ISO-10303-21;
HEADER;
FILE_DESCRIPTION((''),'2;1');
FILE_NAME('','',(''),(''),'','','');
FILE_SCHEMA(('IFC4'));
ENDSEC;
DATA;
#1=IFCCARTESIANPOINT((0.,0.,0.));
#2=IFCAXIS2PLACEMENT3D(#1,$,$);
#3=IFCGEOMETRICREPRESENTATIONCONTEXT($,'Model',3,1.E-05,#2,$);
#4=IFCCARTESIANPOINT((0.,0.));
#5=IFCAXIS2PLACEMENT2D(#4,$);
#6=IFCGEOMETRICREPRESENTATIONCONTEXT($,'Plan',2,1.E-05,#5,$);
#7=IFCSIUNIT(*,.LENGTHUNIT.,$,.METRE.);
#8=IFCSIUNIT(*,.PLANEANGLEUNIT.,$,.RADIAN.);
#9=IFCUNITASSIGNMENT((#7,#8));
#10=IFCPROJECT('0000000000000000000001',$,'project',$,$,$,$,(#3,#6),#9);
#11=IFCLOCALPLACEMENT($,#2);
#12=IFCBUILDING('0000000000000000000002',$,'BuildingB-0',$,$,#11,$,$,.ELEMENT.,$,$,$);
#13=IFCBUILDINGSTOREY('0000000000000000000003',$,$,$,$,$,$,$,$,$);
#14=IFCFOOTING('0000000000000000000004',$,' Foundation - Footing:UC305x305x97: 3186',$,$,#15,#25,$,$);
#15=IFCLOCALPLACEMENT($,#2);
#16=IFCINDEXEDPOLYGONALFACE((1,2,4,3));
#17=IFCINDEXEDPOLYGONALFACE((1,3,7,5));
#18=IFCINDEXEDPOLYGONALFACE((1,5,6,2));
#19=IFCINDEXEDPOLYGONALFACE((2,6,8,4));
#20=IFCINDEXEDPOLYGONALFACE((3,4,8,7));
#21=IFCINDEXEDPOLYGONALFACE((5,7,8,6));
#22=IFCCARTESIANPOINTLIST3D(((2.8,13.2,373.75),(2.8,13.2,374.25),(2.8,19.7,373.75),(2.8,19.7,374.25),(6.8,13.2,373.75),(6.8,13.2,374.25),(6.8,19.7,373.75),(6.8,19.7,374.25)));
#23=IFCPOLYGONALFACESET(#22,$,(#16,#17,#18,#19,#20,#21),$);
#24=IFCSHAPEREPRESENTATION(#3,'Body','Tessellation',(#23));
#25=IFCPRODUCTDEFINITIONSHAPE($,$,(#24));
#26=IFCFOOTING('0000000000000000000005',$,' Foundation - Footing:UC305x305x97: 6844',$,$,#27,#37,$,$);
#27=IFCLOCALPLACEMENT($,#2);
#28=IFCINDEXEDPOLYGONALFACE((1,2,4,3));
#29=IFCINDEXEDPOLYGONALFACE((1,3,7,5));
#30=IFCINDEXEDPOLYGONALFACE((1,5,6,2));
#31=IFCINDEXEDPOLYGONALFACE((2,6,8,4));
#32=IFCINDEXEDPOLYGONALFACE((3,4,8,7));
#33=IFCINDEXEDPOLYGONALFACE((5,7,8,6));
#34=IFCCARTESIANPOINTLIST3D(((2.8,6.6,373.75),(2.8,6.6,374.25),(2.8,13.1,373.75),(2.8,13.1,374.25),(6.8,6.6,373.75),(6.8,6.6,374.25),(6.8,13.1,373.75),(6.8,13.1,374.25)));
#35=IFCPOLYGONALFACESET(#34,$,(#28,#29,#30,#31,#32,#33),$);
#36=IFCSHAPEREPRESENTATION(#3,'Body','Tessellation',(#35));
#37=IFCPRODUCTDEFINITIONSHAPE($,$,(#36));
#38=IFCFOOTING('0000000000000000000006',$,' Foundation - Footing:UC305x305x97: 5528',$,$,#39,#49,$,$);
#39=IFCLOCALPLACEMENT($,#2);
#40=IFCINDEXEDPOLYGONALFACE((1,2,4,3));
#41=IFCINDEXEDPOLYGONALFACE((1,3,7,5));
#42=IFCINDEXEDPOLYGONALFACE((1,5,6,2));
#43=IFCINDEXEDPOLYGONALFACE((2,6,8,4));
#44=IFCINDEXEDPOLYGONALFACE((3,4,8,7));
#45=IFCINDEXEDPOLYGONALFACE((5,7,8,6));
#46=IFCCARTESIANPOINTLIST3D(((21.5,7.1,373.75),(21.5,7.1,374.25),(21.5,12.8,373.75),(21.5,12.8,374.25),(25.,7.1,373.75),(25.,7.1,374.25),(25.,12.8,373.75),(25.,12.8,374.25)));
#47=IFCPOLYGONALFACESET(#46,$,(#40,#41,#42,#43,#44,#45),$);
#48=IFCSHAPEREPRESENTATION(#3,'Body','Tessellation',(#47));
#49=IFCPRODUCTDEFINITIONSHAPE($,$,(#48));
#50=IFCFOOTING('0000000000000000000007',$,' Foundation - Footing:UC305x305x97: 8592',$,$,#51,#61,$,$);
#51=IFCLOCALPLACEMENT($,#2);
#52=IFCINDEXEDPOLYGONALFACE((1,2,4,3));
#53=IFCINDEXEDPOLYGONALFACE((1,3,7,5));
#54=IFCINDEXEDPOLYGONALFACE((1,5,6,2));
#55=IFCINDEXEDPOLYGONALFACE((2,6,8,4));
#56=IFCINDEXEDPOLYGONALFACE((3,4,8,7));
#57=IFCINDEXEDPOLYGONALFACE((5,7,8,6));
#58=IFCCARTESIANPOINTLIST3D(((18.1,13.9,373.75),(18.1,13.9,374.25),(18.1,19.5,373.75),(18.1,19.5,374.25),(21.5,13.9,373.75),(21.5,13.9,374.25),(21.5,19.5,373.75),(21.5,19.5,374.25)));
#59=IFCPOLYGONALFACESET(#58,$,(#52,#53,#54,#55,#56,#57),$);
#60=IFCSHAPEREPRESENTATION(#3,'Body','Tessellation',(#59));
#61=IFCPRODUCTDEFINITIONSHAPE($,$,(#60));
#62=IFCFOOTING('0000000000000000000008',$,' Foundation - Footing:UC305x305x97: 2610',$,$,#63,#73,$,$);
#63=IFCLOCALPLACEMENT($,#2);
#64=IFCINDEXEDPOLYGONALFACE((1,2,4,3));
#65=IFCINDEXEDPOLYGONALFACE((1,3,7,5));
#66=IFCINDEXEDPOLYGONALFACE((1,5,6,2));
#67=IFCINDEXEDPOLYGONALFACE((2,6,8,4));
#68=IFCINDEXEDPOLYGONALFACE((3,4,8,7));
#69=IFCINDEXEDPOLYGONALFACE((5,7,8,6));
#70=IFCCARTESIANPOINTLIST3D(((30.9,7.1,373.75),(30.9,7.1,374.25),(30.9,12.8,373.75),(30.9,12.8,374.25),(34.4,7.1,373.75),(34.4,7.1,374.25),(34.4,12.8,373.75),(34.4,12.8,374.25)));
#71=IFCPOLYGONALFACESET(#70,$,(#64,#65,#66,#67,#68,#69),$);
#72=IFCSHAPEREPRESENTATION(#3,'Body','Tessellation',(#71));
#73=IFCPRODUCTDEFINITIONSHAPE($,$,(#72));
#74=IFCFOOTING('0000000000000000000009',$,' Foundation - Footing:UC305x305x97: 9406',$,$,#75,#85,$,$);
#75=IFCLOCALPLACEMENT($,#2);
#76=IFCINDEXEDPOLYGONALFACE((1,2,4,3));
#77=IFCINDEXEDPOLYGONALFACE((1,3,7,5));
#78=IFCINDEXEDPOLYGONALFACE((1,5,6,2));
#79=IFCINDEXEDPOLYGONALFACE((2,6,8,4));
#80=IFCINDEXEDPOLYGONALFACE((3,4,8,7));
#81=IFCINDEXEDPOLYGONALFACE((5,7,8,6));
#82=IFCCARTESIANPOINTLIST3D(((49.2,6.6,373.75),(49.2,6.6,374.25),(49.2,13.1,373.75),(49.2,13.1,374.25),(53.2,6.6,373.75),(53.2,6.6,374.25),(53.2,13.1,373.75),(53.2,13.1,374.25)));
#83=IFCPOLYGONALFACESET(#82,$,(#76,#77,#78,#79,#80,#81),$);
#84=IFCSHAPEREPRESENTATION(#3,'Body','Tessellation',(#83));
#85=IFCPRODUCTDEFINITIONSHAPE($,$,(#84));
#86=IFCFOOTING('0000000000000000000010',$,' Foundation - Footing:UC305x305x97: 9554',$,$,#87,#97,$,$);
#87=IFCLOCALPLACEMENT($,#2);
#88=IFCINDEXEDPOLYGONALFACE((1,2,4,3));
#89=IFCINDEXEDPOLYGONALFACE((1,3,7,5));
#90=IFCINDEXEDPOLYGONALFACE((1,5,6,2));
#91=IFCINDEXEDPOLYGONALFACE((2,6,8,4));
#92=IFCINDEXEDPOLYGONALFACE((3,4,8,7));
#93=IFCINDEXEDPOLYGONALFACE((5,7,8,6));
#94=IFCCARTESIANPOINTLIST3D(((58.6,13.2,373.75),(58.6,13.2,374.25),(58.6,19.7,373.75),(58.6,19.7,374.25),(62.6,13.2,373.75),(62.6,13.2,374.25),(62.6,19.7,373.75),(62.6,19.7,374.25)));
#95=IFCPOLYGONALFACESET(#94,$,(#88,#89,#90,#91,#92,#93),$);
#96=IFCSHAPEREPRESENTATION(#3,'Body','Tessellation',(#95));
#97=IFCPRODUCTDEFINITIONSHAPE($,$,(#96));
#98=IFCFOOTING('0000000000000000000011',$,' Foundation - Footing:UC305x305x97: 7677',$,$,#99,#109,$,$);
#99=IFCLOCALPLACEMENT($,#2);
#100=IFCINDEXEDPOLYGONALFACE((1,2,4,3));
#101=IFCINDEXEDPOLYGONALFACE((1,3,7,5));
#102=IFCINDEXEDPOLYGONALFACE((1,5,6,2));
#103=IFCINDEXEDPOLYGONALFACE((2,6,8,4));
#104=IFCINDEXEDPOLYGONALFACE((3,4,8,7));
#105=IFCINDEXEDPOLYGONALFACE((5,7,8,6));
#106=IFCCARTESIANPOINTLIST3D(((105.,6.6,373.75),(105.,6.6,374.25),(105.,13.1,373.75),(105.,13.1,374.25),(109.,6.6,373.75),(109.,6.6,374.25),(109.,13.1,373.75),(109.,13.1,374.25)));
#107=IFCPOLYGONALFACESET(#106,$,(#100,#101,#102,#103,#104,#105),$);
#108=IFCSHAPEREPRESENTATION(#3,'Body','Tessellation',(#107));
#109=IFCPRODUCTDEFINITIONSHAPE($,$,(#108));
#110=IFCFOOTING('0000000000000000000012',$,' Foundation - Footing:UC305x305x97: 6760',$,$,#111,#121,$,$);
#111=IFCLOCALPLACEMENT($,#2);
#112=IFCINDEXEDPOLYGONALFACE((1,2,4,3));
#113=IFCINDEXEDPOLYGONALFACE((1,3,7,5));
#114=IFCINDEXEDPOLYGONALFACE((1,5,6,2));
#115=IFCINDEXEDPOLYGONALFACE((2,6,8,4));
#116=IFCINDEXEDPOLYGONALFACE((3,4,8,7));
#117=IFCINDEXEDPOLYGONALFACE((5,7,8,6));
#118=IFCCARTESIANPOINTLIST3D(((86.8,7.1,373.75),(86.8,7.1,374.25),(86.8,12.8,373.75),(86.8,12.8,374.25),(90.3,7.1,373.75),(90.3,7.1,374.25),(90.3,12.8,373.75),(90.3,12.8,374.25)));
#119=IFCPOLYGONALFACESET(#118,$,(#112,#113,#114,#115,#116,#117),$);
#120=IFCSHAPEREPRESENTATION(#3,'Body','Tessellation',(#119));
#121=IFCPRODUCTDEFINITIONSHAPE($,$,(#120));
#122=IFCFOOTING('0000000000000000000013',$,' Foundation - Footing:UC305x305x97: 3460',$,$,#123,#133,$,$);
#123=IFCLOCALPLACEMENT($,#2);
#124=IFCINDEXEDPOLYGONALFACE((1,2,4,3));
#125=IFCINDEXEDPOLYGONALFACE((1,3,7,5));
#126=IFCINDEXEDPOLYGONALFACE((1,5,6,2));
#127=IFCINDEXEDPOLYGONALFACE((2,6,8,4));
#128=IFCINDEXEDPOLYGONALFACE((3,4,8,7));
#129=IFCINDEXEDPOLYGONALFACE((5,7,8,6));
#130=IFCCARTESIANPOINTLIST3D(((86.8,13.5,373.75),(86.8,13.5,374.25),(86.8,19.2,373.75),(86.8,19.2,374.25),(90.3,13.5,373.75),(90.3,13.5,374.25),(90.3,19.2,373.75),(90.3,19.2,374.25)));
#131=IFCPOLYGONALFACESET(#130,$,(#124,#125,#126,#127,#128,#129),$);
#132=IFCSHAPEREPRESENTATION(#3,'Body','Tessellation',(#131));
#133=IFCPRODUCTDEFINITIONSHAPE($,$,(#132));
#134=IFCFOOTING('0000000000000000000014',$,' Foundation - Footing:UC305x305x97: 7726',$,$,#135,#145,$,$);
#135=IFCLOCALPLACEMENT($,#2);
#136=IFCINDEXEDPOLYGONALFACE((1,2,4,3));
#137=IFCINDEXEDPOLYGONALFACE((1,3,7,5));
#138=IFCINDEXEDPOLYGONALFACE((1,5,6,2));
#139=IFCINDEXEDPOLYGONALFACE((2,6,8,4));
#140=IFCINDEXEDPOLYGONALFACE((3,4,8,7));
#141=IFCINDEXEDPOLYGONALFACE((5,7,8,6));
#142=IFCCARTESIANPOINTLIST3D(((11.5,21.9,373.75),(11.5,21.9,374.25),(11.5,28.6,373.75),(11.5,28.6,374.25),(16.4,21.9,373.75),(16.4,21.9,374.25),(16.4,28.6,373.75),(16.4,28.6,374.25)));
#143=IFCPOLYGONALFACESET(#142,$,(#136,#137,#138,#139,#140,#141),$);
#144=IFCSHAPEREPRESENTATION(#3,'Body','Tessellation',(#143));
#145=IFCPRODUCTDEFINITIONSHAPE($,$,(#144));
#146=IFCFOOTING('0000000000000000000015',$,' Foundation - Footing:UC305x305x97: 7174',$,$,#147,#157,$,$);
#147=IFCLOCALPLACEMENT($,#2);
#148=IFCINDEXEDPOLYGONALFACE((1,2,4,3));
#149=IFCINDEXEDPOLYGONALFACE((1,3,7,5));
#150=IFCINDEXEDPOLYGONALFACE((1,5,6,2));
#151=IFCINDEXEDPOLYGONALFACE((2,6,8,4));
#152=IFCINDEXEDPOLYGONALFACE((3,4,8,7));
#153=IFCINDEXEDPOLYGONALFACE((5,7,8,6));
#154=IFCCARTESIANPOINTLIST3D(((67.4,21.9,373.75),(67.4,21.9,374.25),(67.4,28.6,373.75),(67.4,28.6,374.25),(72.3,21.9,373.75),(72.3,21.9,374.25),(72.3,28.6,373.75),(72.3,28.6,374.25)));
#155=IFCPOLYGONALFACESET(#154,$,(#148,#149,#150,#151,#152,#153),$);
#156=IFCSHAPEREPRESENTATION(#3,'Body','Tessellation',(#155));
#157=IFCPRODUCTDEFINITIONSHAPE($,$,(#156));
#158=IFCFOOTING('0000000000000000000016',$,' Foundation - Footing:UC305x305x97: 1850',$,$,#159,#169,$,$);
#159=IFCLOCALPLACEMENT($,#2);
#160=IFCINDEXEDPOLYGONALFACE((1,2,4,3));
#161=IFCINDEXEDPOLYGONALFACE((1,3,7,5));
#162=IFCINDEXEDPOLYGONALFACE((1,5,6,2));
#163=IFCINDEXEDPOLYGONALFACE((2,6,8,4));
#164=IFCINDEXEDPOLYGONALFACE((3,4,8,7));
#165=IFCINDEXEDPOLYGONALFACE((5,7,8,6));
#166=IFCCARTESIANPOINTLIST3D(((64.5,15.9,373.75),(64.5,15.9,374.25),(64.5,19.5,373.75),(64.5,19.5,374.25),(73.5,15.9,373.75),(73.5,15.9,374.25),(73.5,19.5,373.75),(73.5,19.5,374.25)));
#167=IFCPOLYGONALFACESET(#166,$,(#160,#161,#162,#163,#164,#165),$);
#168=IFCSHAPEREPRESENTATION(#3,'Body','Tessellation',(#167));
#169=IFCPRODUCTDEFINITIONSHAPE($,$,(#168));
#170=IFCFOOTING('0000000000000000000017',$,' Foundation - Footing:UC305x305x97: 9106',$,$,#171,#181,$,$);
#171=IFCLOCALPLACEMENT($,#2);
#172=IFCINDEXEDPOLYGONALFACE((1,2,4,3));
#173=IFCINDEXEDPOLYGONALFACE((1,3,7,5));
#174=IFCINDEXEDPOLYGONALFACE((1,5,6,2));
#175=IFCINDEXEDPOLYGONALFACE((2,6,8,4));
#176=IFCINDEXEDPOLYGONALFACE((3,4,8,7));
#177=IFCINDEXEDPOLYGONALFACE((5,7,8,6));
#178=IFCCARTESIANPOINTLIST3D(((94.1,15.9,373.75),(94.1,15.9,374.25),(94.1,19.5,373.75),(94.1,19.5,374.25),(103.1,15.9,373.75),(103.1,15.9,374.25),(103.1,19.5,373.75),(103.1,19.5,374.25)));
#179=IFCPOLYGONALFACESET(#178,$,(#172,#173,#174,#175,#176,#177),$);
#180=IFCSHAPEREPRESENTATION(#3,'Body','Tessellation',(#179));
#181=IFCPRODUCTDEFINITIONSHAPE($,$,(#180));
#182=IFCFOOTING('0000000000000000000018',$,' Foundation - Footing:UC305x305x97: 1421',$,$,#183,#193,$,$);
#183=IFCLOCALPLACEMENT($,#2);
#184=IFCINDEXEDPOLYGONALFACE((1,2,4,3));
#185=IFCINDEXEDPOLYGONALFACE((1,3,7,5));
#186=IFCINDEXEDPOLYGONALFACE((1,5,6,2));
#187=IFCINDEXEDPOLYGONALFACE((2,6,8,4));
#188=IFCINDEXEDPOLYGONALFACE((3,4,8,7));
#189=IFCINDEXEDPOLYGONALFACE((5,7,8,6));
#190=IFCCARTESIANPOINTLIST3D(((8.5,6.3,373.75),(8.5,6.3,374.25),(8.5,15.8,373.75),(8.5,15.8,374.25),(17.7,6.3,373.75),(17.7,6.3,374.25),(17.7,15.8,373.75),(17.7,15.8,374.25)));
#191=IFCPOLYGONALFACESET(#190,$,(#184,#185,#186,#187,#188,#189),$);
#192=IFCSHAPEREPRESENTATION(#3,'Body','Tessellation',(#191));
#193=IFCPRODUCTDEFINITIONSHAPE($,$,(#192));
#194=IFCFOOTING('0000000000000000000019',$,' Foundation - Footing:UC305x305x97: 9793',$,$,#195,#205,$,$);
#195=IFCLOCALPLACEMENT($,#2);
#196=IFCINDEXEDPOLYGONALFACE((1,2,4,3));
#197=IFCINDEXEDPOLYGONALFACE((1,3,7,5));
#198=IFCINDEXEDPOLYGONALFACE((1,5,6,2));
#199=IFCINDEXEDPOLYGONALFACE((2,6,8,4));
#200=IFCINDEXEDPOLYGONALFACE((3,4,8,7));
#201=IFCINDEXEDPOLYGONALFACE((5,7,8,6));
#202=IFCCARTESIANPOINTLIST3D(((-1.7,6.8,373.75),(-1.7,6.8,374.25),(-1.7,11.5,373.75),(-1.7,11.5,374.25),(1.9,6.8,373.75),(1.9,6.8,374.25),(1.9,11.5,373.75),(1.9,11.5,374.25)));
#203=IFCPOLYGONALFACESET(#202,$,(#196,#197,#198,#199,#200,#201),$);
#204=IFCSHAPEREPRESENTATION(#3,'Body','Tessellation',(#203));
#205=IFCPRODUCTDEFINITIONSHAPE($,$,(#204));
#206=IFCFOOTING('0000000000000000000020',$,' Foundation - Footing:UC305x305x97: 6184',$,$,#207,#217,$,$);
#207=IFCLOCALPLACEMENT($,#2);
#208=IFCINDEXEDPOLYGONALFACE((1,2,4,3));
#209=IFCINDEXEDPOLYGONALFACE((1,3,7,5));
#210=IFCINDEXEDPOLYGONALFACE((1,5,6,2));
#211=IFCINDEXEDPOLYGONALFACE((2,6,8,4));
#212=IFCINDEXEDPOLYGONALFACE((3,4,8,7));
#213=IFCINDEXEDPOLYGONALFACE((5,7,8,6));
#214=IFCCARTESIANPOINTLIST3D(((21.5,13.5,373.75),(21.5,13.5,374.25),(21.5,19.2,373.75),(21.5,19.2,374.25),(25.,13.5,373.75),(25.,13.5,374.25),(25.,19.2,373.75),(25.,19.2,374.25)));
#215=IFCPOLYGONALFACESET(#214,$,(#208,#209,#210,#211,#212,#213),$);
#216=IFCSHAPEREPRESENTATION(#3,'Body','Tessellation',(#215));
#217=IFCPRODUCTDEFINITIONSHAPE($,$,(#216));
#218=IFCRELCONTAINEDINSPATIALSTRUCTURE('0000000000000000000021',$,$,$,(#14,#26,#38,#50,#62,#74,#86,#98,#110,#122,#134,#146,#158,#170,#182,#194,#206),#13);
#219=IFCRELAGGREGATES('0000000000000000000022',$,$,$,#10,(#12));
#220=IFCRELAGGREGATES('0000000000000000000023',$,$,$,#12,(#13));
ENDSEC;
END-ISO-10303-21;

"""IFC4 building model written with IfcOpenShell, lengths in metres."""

from ifc_helpers import new_model, si_unit, origin, origin_2d, place, context, project, spatial, polyline, outline, extrude, element, save


model = new_model("IFC4")

# Units and contexts
model_context = context("Model", 3, precision=1e-05, world=origin())
plan_context = context("Plan", 2, precision=1e-05, world=origin_2d())
ifc_project = project(units=[si_unit("LENGTHUNIT", "METRE"), si_unit("PLANEANGLEUNIT", "RADIAN")], contexts=[model_context, plan_context])

# Building, storey
building_placement = place(None, origin())
building = spatial("IfcBuilding", under=ifc_project, at=building_placement, Name="BuildingB-0", CompositionType="ELEMENT")
storey = spatial("IfcBuildingStorey", under=building)

# Footings
element("IfcFooting", 1, inside=storey, Name=" Foundation - Footing:UC305x305x97: 3186", context=model_context, shape_type="SweptSolid", body=[
    extrude(outline(polyline([(6.8, 19.7, 373.75), (2.8, 19.7, 373.75), (2.8, 13.2, 373.75), (6.8, 13.2, 373.75), (6.8, 19.7, 373.75)])), None, (0.0, 0.0, 1.0), 0.5),
])
element("IfcFooting", 2, inside=storey, Name=" Foundation - Footing:UC305x305x97: 6844", context=model_context, shape_type="SweptSolid", body=[
    extrude(outline(polyline([(6.8, 13.1, 373.75), (2.8, 13.1, 373.75), (2.8, 6.6, 373.75), (6.8, 6.6, 373.75), (6.8, 13.1, 373.75)])), None, (0.0, 0.0, 1.0), 0.5),
])
element("IfcFooting", 3, inside=storey, Name=" Foundation - Footing:UC305x305x97: 5528", context=model_context, shape_type="SweptSolid", body=[
    extrude(outline(polyline([(25.0, 12.8, 373.75), (21.5, 12.8, 373.75), (21.5, 7.1, 373.75), (25.0, 7.1, 373.75), (25.0, 12.8, 373.75)])), None, (0.0, 0.0, 1.0), 0.5),
])
element("IfcFooting", 4, inside=storey, Name=" Foundation - Footing:UC305x305x97: 8592", context=model_context, shape_type="SweptSolid", body=[
    extrude(outline(polyline([(21.5, 19.5, 373.75), (18.1, 19.5, 373.75), (18.1, 13.9, 373.75), (21.5, 13.9, 373.75), (21.5, 19.5, 373.75)])), None, (0.0, 0.0, 1.0), 0.5),
])
element("IfcFooting", 5, inside=storey, Name=" Foundation - Footing:UC305x305x97: 2610", context=model_context, shape_type="SweptSolid", body=[
    extrude(outline(polyline([(34.4, 12.8, 373.75), (30.9, 12.8, 373.75), (30.9, 7.1, 373.75), (34.4, 7.1, 373.75), (34.4, 12.8, 373.75)])), None, (0.0, 0.0, 1.0), 0.5),
])
element("IfcFooting", 6, inside=storey, Name=" Foundation - Footing:UC305x305x97: 9406", context=model_context, shape_type="SweptSolid", body=[
    extrude(outline(polyline([(53.2, 13.1, 373.75), (49.2, 13.1, 373.75), (49.2, 6.6, 373.75), (53.2, 6.6, 373.75), (53.2, 13.1, 373.75)])), None, (0.0, 0.0, 1.0), 0.5),
])
element("IfcFooting", 7, inside=storey, Name=" Foundation - Footing:UC305x305x97: 9554", context=model_context, shape_type="SweptSolid", body=[
    extrude(outline(polyline([(58.6, 19.7, 373.75), (62.6, 19.7, 373.75), (62.6, 13.2, 373.75), (58.6, 13.2, 373.75), (58.6, 19.7, 373.75)])), None, (0.0, 0.0, 1.0), 0.5),
])
element("IfcFooting", 8, inside=storey, Name=" Foundation - Footing:UC305x305x97: 7677", context=model_context, shape_type="SweptSolid", body=[
    extrude(outline(polyline([(109.0, 13.1, 373.75), (105.0, 13.1, 373.75), (105.0, 6.6, 373.75), (109.0, 6.6, 373.75), (109.0, 13.1, 373.75)])), None, (0.0, 0.0, 1.0), 0.5),
])
element("IfcFooting", 9, inside=storey, Name=" Foundation - Footing:UC305x305x97: 6760", context=model_context, shape_type="SweptSolid", body=[
    extrude(outline(polyline([(86.8, 12.8, 373.75), (90.3, 12.8, 373.75), (90.3, 7.1, 373.75), (86.8, 7.1, 373.75), (86.8, 12.8, 373.75)])), None, (0.0, 0.0, 1.0), 0.5),
])
element("IfcFooting", 10, inside=storey, Name=" Foundation - Footing:UC305x305x97: 3460", context=model_context, shape_type="SweptSolid", body=[
    extrude(outline(polyline([(86.8, 19.2, 373.75), (90.3, 19.2, 373.75), (90.3, 13.5, 373.75), (86.8, 13.5, 373.75), (86.8, 19.2, 373.75)])), None, (0.0, 0.0, 1.0), 0.5),
])
element("IfcFooting", 11, inside=storey, Name=" Foundation - Footing:UC305x305x97: 7726", context=model_context, shape_type="SweptSolid", body=[
    extrude(outline(polyline([(16.4, 21.9, 373.75), (16.4, 28.6, 373.75), (11.5, 28.6, 373.75), (11.5, 21.9, 373.75), (16.4, 21.9, 373.75)])), None, (0.0, 0.0, 1.0), 0.5),
])
element("IfcFooting", 12, inside=storey, Name=" Foundation - Footing:UC305x305x97: 7174", context=model_context, shape_type="SweptSolid", body=[
    extrude(outline(polyline([(67.4, 21.9, 373.75), (67.4, 28.6, 373.75), (72.3, 28.6, 373.75), (72.3, 21.9, 373.75), (67.4, 21.9, 373.75)])), None, (0.0, 0.0, 1.0), 0.5),
])
element("IfcFooting", 13, inside=storey, Name=" Foundation - Footing:UC305x305x97: 1850", context=model_context, shape_type="SweptSolid", body=[
    extrude(outline(polyline([(64.5, 19.5, 373.75), (73.5, 19.5, 373.75), (73.5, 15.9, 373.75), (64.5, 15.9, 373.75), (64.5, 19.5, 373.75)])), None, (0.0, 0.0, 1.0), 0.5),
])
element("IfcFooting", 14, inside=storey, Name=" Foundation - Footing:UC305x305x97: 9106", context=model_context, shape_type="SweptSolid", body=[
    extrude(outline(polyline([(94.1, 19.5, 373.75), (103.1, 19.5, 373.75), (103.1, 15.9, 373.75), (94.1, 15.9, 373.75), (94.1, 19.5, 373.75)])), None, (0.0, 0.0, 1.0), 0.5),
])
element("IfcFooting", 15, inside=storey, Name=" Foundation - Footing:UC305x305x97: 1421", context=model_context, shape_type="SweptSolid", body=[
    extrude(outline(polyline([(8.5, 15.8, 373.75), (17.7, 15.8, 373.75), (17.7, 6.3, 373.75), (8.5, 6.3, 373.75), (8.5, 15.8, 373.75)])), None, (0.0, 0.0, 1.0), 0.5),
])
element("IfcFooting", 16, inside=storey, Name=" Foundation - Footing:UC305x305x97: 9793", context=model_context, shape_type="SweptSolid", body=[
    extrude(outline(polyline([(1.9, 11.5, 373.75), (-1.7, 11.5, 373.75), (-1.7, 6.8, 373.75), (1.9, 6.8, 373.75), (1.9, 11.5, 373.75)])), None, (0.0, 0.0, 1.0), 0.5),
])
element("IfcFooting", 17, inside=storey, Name=" Foundation - Footing:UC305x305x97: 6184", context=model_context, shape_type="SweptSolid", body=[
    extrude(outline(polyline([(25.0, 19.2, 373.75), (21.5, 19.2, 373.75), (21.5, 13.5, 373.75), (25.0, 13.5, 373.75), (25.0, 19.2, 373.75)])), None, (0.0, 0.0, 1.0), 0.5),
])

save(model, "model.ifc")
